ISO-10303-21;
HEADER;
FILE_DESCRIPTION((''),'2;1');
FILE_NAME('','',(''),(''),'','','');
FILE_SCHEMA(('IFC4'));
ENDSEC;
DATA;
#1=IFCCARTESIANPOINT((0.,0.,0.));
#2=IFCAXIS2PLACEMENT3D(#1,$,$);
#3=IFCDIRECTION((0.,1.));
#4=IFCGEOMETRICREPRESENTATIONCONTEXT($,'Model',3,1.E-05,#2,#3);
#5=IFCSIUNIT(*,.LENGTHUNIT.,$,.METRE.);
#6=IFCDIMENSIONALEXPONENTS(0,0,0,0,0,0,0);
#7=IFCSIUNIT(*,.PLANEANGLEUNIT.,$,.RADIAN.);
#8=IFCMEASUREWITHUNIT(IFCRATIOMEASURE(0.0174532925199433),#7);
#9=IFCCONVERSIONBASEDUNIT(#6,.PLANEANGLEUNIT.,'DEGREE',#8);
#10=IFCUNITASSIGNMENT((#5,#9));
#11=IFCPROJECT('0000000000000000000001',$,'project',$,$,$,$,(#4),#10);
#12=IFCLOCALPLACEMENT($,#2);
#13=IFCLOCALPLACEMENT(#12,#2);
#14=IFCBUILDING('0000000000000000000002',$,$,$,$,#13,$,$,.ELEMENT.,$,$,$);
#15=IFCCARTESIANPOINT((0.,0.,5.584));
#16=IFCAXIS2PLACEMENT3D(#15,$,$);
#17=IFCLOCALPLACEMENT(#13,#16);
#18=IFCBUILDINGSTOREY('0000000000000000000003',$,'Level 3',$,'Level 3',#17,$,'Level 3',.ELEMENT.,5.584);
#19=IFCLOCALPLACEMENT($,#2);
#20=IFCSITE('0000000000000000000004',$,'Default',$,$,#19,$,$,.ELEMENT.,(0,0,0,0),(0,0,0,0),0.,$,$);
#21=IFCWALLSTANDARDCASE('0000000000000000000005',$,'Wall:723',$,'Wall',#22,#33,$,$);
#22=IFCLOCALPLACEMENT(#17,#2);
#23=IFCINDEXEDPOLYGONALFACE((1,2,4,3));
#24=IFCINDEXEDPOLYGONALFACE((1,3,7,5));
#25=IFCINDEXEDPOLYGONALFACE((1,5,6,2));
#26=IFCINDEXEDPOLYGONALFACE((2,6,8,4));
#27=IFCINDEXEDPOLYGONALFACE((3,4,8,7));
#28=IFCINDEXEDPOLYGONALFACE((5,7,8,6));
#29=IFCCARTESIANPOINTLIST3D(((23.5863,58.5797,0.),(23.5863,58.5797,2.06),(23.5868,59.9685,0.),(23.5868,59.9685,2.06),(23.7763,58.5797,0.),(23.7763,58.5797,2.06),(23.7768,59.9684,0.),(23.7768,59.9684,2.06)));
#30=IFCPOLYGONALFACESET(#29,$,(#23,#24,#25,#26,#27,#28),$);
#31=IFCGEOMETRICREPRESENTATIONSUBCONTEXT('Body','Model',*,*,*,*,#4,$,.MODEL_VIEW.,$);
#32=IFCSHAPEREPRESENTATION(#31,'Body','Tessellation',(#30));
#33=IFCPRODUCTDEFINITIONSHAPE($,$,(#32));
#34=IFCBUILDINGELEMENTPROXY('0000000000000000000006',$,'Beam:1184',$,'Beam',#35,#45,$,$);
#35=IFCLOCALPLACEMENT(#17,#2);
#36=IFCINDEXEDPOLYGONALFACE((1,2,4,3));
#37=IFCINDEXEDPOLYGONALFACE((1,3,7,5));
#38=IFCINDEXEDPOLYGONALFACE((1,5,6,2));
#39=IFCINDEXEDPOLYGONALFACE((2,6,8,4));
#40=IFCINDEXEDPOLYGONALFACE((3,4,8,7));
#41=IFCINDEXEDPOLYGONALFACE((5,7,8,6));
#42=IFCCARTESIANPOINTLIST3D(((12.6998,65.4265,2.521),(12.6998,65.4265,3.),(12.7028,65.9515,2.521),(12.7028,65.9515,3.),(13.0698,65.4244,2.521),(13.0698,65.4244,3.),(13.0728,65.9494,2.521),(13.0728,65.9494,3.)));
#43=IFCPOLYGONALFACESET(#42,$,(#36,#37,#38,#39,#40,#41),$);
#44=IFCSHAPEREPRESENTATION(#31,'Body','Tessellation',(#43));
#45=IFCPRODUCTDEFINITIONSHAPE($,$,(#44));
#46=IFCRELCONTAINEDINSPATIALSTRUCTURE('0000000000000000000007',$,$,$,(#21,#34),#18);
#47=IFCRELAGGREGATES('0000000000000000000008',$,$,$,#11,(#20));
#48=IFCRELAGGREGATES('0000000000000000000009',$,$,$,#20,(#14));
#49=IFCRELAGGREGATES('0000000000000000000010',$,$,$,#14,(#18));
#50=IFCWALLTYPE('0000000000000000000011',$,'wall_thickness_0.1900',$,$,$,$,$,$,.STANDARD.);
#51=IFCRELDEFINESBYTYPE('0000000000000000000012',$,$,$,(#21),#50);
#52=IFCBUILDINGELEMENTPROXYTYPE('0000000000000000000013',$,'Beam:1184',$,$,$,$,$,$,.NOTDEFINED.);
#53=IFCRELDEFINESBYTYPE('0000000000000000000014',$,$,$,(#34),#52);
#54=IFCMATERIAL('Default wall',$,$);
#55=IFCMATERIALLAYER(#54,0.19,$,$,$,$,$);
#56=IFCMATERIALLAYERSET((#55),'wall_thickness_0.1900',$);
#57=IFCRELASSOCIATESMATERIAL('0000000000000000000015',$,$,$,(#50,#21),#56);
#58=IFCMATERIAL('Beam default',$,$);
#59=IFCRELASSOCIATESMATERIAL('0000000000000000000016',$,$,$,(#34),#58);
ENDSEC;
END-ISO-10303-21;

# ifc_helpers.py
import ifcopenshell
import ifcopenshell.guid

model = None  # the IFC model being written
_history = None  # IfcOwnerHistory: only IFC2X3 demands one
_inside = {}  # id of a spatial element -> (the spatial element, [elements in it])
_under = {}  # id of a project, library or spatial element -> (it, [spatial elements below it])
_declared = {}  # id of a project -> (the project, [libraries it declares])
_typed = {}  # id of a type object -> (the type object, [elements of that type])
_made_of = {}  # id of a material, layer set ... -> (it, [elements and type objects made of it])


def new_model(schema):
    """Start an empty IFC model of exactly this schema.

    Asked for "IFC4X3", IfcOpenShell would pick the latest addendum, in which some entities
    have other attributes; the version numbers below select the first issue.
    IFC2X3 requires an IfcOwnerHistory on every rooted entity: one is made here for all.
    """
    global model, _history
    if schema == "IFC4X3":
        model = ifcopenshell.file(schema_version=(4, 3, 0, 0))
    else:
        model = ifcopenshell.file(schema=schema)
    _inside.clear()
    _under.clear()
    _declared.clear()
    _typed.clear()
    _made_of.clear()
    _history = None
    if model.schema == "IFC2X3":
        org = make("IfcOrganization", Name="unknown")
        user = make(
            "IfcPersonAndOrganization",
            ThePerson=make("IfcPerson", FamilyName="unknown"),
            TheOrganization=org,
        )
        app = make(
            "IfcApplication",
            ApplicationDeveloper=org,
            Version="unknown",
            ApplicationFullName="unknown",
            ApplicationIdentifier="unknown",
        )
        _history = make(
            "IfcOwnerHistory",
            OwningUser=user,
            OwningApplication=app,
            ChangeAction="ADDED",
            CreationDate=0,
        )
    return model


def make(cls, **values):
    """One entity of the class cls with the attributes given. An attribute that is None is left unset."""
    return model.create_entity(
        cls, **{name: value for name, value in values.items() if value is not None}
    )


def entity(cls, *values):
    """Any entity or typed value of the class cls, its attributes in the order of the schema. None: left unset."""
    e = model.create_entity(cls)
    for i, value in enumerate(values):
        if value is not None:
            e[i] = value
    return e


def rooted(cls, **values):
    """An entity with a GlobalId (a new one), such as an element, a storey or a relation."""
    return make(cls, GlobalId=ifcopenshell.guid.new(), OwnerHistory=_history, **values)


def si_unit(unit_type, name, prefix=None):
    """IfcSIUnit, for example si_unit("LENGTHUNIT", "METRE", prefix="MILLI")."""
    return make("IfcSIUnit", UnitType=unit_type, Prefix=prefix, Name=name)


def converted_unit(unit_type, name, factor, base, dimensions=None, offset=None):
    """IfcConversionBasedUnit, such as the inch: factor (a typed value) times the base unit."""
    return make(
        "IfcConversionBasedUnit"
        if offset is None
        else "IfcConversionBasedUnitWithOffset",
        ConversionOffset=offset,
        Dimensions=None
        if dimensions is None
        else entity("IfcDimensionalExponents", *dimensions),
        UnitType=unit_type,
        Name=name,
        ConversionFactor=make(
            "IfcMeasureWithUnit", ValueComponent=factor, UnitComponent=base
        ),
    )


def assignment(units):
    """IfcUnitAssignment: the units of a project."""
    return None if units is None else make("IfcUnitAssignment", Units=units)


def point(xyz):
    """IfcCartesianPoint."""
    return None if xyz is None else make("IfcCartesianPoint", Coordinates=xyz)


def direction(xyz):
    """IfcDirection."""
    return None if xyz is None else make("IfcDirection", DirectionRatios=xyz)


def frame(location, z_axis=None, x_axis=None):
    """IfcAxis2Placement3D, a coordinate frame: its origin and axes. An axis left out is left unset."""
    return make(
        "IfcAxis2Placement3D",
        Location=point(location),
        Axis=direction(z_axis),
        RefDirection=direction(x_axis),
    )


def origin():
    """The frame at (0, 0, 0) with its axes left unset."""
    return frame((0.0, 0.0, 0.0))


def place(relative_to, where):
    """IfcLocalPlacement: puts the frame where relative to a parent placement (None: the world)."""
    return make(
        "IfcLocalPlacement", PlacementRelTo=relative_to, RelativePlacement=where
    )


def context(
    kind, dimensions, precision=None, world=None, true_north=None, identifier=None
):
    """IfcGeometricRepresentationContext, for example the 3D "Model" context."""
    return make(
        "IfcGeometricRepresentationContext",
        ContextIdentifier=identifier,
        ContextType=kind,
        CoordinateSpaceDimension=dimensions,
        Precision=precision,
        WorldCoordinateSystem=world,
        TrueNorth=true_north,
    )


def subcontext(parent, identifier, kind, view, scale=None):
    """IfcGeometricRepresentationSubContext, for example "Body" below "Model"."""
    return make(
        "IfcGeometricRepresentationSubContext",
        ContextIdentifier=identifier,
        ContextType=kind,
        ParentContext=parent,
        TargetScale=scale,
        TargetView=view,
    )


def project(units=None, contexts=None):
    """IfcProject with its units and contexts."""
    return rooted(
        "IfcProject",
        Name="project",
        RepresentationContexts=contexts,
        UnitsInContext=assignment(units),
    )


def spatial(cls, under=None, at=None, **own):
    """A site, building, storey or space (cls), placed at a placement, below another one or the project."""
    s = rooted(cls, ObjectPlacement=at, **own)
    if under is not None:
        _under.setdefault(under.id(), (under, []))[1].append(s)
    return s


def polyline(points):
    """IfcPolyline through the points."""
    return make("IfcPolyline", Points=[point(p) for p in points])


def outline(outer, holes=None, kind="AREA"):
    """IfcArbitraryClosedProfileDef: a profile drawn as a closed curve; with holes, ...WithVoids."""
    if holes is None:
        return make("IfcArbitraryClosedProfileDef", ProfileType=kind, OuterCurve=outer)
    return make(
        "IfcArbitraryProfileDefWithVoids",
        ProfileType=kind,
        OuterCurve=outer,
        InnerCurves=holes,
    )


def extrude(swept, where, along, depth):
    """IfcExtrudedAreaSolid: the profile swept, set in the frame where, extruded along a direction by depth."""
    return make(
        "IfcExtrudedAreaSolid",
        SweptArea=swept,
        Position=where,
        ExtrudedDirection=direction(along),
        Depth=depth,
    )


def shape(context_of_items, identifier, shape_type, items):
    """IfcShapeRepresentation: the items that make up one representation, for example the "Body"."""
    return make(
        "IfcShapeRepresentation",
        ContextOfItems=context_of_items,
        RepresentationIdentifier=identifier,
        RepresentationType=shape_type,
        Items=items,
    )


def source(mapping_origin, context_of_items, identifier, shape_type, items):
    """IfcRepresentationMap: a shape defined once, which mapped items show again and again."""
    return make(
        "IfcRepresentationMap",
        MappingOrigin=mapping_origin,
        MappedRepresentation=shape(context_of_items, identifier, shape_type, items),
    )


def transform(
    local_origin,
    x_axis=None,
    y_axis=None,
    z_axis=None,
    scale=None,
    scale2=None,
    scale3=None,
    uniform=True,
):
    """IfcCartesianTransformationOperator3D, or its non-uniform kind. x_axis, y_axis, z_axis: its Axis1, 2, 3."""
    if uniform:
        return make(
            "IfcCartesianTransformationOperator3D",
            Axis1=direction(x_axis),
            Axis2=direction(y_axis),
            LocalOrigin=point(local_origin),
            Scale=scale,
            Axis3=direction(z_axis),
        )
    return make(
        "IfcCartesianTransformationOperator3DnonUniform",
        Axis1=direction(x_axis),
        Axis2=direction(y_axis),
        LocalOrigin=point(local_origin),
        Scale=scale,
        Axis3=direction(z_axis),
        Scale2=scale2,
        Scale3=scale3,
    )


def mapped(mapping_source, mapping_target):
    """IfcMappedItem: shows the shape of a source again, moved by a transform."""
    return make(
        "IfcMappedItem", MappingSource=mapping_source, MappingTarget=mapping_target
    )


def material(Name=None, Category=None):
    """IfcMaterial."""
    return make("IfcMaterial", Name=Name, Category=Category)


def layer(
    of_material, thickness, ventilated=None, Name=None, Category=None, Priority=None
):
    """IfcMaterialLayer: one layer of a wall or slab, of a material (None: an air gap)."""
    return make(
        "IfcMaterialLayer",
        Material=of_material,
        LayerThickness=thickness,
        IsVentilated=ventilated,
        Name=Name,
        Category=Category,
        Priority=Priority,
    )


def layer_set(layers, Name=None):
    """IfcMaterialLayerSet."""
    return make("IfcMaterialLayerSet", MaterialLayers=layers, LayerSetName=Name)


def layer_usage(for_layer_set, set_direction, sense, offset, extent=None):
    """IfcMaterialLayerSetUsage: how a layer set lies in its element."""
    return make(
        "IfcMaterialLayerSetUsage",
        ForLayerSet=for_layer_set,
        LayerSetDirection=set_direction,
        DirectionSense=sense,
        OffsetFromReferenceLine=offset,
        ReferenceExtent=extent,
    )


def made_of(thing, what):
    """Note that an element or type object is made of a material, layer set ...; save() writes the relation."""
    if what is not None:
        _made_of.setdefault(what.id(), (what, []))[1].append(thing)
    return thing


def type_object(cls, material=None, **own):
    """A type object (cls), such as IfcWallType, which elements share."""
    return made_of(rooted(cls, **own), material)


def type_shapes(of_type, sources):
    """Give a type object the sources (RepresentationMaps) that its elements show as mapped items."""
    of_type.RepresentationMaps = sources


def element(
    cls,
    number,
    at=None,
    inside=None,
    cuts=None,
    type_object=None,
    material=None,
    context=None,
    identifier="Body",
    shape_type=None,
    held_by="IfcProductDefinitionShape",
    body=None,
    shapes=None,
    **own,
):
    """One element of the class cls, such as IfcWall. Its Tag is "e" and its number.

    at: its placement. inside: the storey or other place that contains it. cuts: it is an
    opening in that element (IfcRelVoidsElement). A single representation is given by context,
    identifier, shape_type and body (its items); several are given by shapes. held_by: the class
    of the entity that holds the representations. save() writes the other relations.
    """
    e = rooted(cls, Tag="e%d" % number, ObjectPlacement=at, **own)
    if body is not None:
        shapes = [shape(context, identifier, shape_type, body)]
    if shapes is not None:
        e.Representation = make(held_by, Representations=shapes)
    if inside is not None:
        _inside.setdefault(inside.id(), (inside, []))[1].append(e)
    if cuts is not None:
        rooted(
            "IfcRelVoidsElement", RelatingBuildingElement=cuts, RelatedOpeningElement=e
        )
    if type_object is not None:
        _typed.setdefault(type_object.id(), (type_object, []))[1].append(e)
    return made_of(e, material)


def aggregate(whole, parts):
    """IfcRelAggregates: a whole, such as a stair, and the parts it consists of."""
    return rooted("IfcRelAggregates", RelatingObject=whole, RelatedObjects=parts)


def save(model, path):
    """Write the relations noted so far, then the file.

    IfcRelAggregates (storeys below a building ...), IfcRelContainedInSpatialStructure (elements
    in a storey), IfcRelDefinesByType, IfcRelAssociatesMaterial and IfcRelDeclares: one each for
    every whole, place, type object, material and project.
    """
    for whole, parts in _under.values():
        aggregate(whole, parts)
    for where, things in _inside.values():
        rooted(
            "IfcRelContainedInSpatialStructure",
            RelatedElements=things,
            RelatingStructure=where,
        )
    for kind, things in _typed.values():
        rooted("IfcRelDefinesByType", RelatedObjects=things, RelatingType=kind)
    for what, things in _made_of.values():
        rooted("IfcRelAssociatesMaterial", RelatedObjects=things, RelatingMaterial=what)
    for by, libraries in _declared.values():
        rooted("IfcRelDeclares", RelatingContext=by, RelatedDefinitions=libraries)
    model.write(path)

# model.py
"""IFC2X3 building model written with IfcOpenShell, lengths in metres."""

from ifc_helpers import new_model, entity, si_unit, converted_unit, direction, frame, origin, place, context, subcontext, project, spatial, polyline, outline, extrude, source, transform, mapped, material, layer, layer_set, layer_usage, type_object, type_shapes, element, save


model = new_model("IFC2X3")

# Units and contexts
model_context = context("Model", 3, precision=1e-05, world=origin(), true_north=direction((0.0, 1.0)))
body_context = subcontext(model_context, "Body", "Model", "MODEL_VIEW")
ifc_project = project(units=[si_unit("LENGTHUNIT", "METRE"), converted_unit("PLANEANGLEUNIT", "DEGREE", entity("IfcRatioMeasure", 0.0174532925199433), si_unit("PLANEANGLEUNIT", "RADIAN"), dimensions=[0, 0, 0, 0, 0, 0, 0])], contexts=[model_context])

# Site, building, storey
site_placement = place(None, origin())
site = spatial("IfcSite", under=ifc_project, at=site_placement, Name="Default", CompositionType="ELEMENT", RefLatitude=(0, 0, 0, 0), RefLongitude=(0, 0, 0, 0), RefElevation=0.0)
placement_1 = place(None, origin())
building_placement = place(placement_1, origin())
building = spatial("IfcBuilding", under=site, at=building_placement, CompositionType="ELEMENT")
storey_placement = place(building_placement, frame((0.0, 0.0, 5.584)))
storey = spatial("IfcBuildingStorey", under=building, at=storey_placement, Name="Level 3", ObjectType="Level 3", LongName="Level 3", CompositionType="ELEMENT", Elevation=5.584)

# Shared definitions
ifc_material_1 = material(Name="Default wall")

# Wall
ifc_layer_1 = layer(ifc_material_1, 0.19)
ifc_layer_set_1 = layer_set([ifc_layer_1], Name="wall_thickness_0.1900")
ifc_layer_usage_1 = layer_usage(ifc_layer_set_1, "AXIS2", "POSITIVE", -0.095)
wall_type_1 = type_object("IfcWallType", Name="wall_thickness_0.1900", PredefinedType="STANDARD", material=ifc_layer_set_1)
wall_1_placement = place(storey_placement, frame((23.6818, 59.9685, 0.0), z_axis=(0.0, 0.0, 1.0), x_axis=(-0.000352, -1.0, 0.0)))
element("IfcWallStandardCase", 1, at=wall_1_placement, inside=storey, type_object=wall_type_1, material=ifc_layer_usage_1, Name="Wall:723", ObjectType="Wall", context=body_context, shape_type="SweptSolid", body=[
    extrude(outline(polyline([(1.3888, -0.095), (1.3888, 0.095), (0.0, 0.095), (0.0, -0.095), (1.3888, -0.095)])), origin(), (0.0, 0.0, 1.0), 2.06),
])

# Building element proxy
ifc_material_2 = material(Name="Beam default")
building_element_proxy_type = type_object("IfcBuildingElementProxyType", Name="Beam:1184", PredefinedType="NOTDEFINED")
shared_shape_1 = source(origin(), body_context, "Body", "SweptSolid", [
    extrude(outline(polyline([(0.525, -0.185), (0.525, 0.185), (0.0, 0.185), (0.0, -0.185), (0.525, -0.185)])), origin(), (0.0, 0.0, 1.0), 0.479),
])
type_shapes(building_element_proxy_type, [shared_shape_1])
placement_2 = place(building_placement, frame((0.0, 0.0, 8.105)))
proxy_placement = place(placement_2, frame((12.8878, 65.9504, 0.0), z_axis=(0.0, 0.0, 1.0), x_axis=(-0.005611, -0.999984, 0.0)))
element("IfcBuildingElementProxy", 2, at=proxy_placement, inside=storey, type_object=building_element_proxy_type, material=ifc_material_2, Name="Beam:1184", ObjectType="Beam", context=body_context, shape_type="MappedRepresentation", body=[
    mapped(shared_shape_1, transform((0.0, 0.0, 0.0), scale=1.0)),
])

save(model, "model.ifc")
